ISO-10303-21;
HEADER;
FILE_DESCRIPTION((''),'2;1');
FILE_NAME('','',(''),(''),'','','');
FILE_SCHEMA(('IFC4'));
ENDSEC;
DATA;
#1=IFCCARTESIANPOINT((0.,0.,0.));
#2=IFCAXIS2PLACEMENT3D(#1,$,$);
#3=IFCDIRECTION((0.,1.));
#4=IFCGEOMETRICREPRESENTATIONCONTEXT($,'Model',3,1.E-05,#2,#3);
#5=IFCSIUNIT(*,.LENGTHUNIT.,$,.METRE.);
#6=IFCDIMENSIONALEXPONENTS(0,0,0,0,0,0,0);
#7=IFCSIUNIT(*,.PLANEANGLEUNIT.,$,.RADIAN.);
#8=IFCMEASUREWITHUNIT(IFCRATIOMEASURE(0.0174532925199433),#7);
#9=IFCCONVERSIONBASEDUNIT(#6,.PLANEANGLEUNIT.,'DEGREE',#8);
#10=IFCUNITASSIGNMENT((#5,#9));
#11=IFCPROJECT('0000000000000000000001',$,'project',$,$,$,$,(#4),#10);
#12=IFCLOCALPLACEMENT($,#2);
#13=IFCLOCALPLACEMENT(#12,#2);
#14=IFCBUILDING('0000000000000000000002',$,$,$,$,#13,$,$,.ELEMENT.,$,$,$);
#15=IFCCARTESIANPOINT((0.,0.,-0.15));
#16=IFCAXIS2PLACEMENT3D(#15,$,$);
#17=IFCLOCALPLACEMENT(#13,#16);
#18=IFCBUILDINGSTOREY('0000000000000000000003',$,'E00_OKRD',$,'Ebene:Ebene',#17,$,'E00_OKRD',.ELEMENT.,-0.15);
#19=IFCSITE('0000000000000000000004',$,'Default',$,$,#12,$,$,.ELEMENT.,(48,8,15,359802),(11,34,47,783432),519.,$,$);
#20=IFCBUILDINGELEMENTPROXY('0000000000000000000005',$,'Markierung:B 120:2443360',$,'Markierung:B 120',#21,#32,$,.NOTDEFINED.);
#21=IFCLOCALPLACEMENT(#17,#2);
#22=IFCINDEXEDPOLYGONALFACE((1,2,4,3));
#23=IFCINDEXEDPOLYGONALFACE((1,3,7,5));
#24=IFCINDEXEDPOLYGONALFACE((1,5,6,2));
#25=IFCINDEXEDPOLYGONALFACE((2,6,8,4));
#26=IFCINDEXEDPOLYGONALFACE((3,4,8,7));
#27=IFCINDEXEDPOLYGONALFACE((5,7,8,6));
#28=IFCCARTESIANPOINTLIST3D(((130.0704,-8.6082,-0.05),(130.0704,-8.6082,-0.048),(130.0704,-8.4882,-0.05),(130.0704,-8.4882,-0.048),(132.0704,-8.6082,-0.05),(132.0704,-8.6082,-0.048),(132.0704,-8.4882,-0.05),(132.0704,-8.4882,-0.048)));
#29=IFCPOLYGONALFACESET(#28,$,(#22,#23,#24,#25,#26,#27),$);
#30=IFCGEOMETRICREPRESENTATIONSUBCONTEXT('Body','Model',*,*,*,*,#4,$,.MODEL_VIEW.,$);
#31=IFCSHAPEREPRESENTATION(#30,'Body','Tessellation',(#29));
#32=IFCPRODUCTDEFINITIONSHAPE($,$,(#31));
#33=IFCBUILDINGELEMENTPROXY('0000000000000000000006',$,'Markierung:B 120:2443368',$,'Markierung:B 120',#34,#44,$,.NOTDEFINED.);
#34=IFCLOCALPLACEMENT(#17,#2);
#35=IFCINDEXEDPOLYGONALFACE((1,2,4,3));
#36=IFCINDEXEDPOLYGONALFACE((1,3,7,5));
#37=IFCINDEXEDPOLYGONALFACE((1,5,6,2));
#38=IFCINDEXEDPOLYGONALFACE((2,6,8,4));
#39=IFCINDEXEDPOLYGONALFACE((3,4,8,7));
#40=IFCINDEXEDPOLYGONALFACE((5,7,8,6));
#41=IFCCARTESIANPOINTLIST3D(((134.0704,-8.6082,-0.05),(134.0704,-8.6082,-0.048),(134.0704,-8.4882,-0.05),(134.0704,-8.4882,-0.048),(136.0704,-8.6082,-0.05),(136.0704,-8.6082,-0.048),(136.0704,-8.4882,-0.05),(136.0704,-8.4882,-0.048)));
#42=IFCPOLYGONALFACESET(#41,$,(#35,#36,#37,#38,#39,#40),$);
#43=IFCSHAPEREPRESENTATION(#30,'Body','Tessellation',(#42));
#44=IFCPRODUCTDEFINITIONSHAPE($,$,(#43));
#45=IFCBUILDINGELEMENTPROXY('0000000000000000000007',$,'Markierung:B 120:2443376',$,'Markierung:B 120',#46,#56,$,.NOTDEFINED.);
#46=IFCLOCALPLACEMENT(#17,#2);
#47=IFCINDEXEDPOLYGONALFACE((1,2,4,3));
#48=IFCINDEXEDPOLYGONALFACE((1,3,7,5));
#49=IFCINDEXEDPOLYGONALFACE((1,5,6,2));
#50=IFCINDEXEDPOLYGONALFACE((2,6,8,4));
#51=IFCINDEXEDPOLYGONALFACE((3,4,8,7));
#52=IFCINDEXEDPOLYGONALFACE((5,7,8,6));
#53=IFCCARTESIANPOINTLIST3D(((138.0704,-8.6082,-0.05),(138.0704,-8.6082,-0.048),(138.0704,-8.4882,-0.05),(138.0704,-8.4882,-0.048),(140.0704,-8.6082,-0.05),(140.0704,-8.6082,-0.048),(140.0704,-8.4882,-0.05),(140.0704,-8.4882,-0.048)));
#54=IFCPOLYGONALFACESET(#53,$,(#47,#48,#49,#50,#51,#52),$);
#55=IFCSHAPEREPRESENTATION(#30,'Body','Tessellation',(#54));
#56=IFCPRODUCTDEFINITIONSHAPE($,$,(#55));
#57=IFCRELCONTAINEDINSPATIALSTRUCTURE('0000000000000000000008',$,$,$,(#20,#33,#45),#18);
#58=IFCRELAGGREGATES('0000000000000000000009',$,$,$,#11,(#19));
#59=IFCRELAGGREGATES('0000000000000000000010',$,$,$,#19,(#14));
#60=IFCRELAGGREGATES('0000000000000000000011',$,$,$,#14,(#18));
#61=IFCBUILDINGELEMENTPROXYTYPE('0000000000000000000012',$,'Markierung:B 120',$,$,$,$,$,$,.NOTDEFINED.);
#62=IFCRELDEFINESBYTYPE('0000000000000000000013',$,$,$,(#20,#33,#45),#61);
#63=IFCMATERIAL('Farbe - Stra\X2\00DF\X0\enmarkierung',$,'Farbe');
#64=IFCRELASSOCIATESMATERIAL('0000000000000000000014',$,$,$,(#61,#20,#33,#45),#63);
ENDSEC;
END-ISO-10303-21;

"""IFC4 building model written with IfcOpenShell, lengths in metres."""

from ifc_helpers import new_model, entity, si_unit, converted_unit, direction, frame, frame_2d, origin, place, context, subcontext, project, spatial, rectangle, extrude, source, transform, mapped, material, type_object, type_shapes, element, save


model = new_model("IFC4")

# Units and contexts
model_context = context("Model", 3, precision=1e-05, world=origin(), true_north=direction((0.0, 1.0)))
body_context = subcontext(model_context, "Body", "Model", "MODEL_VIEW")
ifc_project = project(units=[si_unit("LENGTHUNIT", "METRE"), converted_unit("PLANEANGLEUNIT", "DEGREE", entity("IfcRatioMeasure", 0.0174532925199433), si_unit("PLANEANGLEUNIT", "RADIAN"), dimensions=[0, 0, 0, 0, 0, 0, 0])], contexts=[model_context])

# Site, building, storey
site_placement = place(None, frame((0.0, 0.0, 0.0)))
site = spatial("IfcSite", under=ifc_project, at=site_placement, Name="Default", CompositionType="ELEMENT", RefLatitude=(48, 8, 15, 359802), RefLongitude=(11, 34, 47, 783432), RefElevation=519.0)
building_placement = place(site_placement, origin())
building = spatial("IfcBuilding", under=site, at=building_placement, CompositionType="ELEMENT")
storey_placement = place(building_placement, frame((0.0, 0.0, -0.15)))
storey = spatial("IfcBuildingStorey", under=building, at=storey_placement, Name="E00_OKRD", ObjectType="Ebene:Ebene", LongName="E00_OKRD", CompositionType="ELEMENT", Elevation=-0.15)

# Building element proxies
ifc_material_1 = material(Name="Farbe - Straßenmarkierung", Category="Farbe")
building_element_proxy_type_1 = type_object("IfcBuildingElementProxyType", Name="Markierung:B 120", PredefinedType="NOTDEFINED", material=ifc_material_1)
shared_shape_1 = source(origin(), body_context, "Body", "SweptSolid", [
    extrude(rectangle(XDim=0.12, YDim=2.0, at=frame_2d((0.0, 0.0), x_axis=(1.0, 0.0))), frame((0.06, 1.0, 0.0), z_axis=(0.0, 0.0, 1.0), x_axis=(-1.0, 0.0, 0.0)), (0.0, 0.0, 1.0), 0.002),
])
type_shapes(building_element_proxy_type_1, [shared_shape_1])
for number, where, z_axis, x_axis, name in (
    (1, (132.0704, -8.6082, -0.05), (0.0, 0.0, 1.0), (0.0, 1.0, 0.0), "Markierung:B 120:2443360"),
    (2, (136.0704, -8.6082, -0.05), (0.0, 0.0, 1.0), (0.0, 1.0, 0.0), "Markierung:B 120:2443368"),
    (3, (140.0704, -8.6082, -0.05), (0.0, 0.0, 1.0), (0.0, 1.0, 0.0), "Markierung:B 120:2443376"),
):
    element("IfcBuildingElementProxy", number, at=place(storey_placement, frame(where, z_axis=z_axis, x_axis=x_axis)), inside=storey, type_object=building_element_proxy_type_1, material=ifc_material_1, Name=name, ObjectType="Markierung:B 120", PredefinedType="NOTDEFINED", context=body_context, shape_type="MappedRepresentation", body=[
        mapped(shared_shape_1, transform((0.0, 0.0, 0.0), scale=1.0)),
    ])

save(model, "model.ifc")
